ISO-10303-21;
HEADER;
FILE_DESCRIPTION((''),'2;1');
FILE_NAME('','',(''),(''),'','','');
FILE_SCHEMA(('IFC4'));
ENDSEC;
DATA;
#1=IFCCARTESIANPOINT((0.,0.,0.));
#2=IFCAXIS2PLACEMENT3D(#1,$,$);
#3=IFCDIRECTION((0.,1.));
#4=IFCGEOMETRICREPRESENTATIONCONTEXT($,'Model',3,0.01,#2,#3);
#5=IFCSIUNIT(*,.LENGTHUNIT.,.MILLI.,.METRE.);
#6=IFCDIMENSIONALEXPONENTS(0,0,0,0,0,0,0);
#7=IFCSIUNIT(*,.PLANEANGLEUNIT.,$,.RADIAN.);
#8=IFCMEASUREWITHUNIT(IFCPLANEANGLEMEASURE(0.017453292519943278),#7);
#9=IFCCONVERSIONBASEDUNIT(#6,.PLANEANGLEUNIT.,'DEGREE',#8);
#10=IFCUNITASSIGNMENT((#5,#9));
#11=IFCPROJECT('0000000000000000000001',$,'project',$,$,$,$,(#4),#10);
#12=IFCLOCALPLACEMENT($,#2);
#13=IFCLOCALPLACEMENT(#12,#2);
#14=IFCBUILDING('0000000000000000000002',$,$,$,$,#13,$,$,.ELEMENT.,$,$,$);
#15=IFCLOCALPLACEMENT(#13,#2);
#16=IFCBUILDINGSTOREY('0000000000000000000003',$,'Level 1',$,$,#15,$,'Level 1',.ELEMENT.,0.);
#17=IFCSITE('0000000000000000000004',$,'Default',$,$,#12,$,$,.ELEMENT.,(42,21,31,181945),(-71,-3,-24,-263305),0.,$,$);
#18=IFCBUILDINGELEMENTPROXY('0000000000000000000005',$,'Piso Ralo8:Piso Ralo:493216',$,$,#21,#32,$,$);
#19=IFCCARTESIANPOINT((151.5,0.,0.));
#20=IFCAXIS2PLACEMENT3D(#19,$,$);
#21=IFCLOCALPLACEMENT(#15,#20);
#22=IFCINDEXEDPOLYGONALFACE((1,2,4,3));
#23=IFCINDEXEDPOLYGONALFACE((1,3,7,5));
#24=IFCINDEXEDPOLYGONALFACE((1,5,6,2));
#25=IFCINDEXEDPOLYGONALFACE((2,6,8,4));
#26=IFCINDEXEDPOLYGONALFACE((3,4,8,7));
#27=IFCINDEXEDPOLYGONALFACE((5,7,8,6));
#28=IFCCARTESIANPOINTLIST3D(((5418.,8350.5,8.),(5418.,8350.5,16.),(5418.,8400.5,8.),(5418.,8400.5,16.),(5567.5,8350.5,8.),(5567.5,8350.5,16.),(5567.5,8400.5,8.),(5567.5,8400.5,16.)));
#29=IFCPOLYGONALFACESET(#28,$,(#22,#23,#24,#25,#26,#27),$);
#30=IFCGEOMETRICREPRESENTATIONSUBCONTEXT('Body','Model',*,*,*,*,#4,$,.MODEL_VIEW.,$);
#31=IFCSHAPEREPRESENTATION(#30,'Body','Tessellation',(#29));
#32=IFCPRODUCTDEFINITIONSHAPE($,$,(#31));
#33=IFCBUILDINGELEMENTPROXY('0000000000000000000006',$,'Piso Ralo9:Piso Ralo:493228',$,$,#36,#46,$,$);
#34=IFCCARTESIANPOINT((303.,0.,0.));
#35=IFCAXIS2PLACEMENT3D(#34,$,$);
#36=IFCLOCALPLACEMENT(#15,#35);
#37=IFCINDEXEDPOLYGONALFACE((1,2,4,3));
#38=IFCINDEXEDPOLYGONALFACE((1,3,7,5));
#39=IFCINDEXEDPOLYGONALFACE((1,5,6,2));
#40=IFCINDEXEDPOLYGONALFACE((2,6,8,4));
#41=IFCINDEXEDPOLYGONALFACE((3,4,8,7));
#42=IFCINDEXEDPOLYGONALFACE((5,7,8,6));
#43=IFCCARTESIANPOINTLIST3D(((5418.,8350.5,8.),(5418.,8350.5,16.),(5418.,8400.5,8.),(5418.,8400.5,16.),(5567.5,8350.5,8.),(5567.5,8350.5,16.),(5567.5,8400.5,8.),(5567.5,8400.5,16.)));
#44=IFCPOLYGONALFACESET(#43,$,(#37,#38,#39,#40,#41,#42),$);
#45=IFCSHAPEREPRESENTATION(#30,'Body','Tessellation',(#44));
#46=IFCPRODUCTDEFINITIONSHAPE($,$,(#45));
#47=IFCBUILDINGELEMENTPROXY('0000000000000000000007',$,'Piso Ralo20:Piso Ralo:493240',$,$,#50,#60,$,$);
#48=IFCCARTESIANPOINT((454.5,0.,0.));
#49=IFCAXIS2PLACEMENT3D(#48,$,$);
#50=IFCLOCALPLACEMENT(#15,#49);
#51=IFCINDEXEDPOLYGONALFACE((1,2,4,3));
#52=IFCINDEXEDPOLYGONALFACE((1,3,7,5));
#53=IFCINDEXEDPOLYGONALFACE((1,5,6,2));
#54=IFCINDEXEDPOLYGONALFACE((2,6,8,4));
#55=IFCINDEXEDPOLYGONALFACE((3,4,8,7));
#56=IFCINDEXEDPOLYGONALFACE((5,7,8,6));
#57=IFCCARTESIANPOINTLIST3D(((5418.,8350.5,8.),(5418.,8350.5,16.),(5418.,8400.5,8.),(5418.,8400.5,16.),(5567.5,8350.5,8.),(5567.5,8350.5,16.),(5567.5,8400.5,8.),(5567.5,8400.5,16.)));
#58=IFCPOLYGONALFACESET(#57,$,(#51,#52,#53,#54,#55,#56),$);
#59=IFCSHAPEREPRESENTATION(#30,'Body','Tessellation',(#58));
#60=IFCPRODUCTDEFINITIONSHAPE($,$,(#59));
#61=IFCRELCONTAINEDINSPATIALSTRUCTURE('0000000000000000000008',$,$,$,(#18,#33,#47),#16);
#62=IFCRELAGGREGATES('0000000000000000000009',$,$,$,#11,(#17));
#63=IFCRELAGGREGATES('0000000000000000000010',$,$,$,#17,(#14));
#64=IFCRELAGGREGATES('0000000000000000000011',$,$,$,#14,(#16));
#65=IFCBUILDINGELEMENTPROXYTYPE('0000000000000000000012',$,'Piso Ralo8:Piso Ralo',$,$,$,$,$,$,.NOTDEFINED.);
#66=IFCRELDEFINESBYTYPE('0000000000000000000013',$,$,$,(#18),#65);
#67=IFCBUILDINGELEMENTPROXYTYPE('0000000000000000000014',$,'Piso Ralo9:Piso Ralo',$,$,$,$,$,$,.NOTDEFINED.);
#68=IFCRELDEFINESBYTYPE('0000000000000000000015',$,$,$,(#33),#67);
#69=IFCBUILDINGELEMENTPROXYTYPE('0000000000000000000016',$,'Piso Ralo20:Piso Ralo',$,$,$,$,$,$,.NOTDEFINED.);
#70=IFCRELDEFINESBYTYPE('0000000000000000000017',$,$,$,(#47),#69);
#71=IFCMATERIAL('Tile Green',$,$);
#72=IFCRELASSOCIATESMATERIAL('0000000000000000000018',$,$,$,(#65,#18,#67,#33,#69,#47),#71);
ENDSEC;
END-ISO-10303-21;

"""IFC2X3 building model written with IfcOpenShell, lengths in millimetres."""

from ifc_helpers import new_model, entity, si_unit, converted_unit, direction, frame, frame_2d, origin, place, context, subcontext, project, spatial, rectangle, extrude, source, transform, mapped, material, type_object, type_shapes, element, save


model = new_model("IFC2X3")

# Units and contexts
model_context = context("Model", 3, precision=0.01, world=origin(), true_north=direction((0.0, 1.0)))
body_context = subcontext(model_context, "Body", "Model", "MODEL_VIEW")
ifc_project = project(units=[si_unit("LENGTHUNIT", "METRE", prefix="MILLI"), converted_unit("PLANEANGLEUNIT", "DEGREE", entity("IfcPlaneAngleMeasure", 0.017453292519943278), si_unit("PLANEANGLEUNIT", "RADIAN"), dimensions=[0, 0, 0, 0, 0, 0, 0])], contexts=[model_context])

# Site, building, storey
site_placement = place(None, origin())
site = spatial("IfcSite", under=ifc_project, at=site_placement, Name="Default", CompositionType="ELEMENT", RefLatitude=(42, 21, 31, 181945), RefLongitude=(-71, -3, -24, -263305), RefElevation=0.0)
building_placement = place(site_placement, origin())
building = spatial("IfcBuilding", under=site, at=building_placement, CompositionType="ELEMENT")
storey_placement = place(building_placement, origin())
storey = spatial("IfcBuildingStorey", under=building, at=storey_placement, Name="Level 1", LongName="Level 1", CompositionType="ELEMENT", Elevation=0.0)

# Building element proxies
ifc_material_1 = material(Name="Tile Green")
building_element_proxy_type_1 = type_object("IfcBuildingElementProxyType", Name="Piso Ralo8:Piso Ralo", PredefinedType="NOTDEFINED", material=ifc_material_1)
shared_shape_1 = source(origin(), body_context, "Body", "SweptSolid", [
    extrude(rectangle(XDim=149.5, YDim=50.0, at=frame_2d((0.0, 0.0), x_axis=(1.0, 0.0))), frame((5492.7, 8375.5, 8.0), z_axis=(0.0, 0.0, 1.0), x_axis=(-1.0, 0.0, 0.0)), (0.0, 0.0, 1.0), 8.0),
])
type_shapes(building_element_proxy_type_1, [shared_shape_1])
proxy_1_placement = place(storey_placement, frame((151.5, 0.0, 0.0)))
element("IfcBuildingElementProxy", 1, at=proxy_1_placement, inside=storey, type_object=building_element_proxy_type_1, material=ifc_material_1, Name="Piso Ralo8:Piso Ralo:493216", context=body_context, shape_type="MappedRepresentation", body=[
    mapped(shared_shape_1, transform((0.0, 0.0, 0.0), scale=1.0)),
])
building_element_proxy_type_2 = type_object("IfcBuildingElementProxyType", Name="Piso Ralo9:Piso Ralo", PredefinedType="NOTDEFINED", material=ifc_material_1)
shared_shape_2 = source(origin(), body_context, "Body", "SweptSolid", [
    extrude(rectangle(XDim=149.5, YDim=50.0, at=frame_2d((0.0, 0.0), x_axis=(1.0, 0.0))), frame((5492.7, 8375.5, 8.0), z_axis=(0.0, 0.0, 1.0), x_axis=(-1.0, 0.0, 0.0)), (0.0, 0.0, 1.0), 8.0),
])
type_shapes(building_element_proxy_type_2, [shared_shape_2])
proxy_2_placement = place(storey_placement, frame((303.0, 0.0, 0.0)))
element("IfcBuildingElementProxy", 2, at=proxy_2_placement, inside=storey, type_object=building_element_proxy_type_2, material=ifc_material_1, Name="Piso Ralo9:Piso Ralo:493228", context=body_context, shape_type="MappedRepresentation", body=[
    mapped(shared_shape_2, transform((0.0, 0.0, 0.0), scale=1.0)),
])
building_element_proxy_type_3 = type_object("IfcBuildingElementProxyType", Name="Piso Ralo20:Piso Ralo", PredefinedType="NOTDEFINED", material=ifc_material_1)
shared_shape_3 = source(origin(), body_context, "Body", "SweptSolid", [
    extrude(rectangle(XDim=149.5, YDim=50.0, at=frame_2d((0.0, 0.0), x_axis=(1.0, 0.0))), frame((5492.7, 8375.5, 8.0), z_axis=(0.0, 0.0, 1.0), x_axis=(-1.0, 0.0, 0.0)), (0.0, 0.0, 1.0), 8.0),
])
type_shapes(building_element_proxy_type_3, [shared_shape_3])
proxy_3_placement = place(storey_placement, frame((454.5, 0.0, 0.0)))
element("IfcBuildingElementProxy", 3, at=proxy_3_placement, inside=storey, type_object=building_element_proxy_type_3, material=ifc_material_1, Name="Piso Ralo20:Piso Ralo:493240", context=body_context, shape_type="MappedRepresentation", body=[
    mapped(shared_shape_3, transform((0.0, 0.0, 0.0), scale=1.0)),
])

save(model, "model.ifc")
